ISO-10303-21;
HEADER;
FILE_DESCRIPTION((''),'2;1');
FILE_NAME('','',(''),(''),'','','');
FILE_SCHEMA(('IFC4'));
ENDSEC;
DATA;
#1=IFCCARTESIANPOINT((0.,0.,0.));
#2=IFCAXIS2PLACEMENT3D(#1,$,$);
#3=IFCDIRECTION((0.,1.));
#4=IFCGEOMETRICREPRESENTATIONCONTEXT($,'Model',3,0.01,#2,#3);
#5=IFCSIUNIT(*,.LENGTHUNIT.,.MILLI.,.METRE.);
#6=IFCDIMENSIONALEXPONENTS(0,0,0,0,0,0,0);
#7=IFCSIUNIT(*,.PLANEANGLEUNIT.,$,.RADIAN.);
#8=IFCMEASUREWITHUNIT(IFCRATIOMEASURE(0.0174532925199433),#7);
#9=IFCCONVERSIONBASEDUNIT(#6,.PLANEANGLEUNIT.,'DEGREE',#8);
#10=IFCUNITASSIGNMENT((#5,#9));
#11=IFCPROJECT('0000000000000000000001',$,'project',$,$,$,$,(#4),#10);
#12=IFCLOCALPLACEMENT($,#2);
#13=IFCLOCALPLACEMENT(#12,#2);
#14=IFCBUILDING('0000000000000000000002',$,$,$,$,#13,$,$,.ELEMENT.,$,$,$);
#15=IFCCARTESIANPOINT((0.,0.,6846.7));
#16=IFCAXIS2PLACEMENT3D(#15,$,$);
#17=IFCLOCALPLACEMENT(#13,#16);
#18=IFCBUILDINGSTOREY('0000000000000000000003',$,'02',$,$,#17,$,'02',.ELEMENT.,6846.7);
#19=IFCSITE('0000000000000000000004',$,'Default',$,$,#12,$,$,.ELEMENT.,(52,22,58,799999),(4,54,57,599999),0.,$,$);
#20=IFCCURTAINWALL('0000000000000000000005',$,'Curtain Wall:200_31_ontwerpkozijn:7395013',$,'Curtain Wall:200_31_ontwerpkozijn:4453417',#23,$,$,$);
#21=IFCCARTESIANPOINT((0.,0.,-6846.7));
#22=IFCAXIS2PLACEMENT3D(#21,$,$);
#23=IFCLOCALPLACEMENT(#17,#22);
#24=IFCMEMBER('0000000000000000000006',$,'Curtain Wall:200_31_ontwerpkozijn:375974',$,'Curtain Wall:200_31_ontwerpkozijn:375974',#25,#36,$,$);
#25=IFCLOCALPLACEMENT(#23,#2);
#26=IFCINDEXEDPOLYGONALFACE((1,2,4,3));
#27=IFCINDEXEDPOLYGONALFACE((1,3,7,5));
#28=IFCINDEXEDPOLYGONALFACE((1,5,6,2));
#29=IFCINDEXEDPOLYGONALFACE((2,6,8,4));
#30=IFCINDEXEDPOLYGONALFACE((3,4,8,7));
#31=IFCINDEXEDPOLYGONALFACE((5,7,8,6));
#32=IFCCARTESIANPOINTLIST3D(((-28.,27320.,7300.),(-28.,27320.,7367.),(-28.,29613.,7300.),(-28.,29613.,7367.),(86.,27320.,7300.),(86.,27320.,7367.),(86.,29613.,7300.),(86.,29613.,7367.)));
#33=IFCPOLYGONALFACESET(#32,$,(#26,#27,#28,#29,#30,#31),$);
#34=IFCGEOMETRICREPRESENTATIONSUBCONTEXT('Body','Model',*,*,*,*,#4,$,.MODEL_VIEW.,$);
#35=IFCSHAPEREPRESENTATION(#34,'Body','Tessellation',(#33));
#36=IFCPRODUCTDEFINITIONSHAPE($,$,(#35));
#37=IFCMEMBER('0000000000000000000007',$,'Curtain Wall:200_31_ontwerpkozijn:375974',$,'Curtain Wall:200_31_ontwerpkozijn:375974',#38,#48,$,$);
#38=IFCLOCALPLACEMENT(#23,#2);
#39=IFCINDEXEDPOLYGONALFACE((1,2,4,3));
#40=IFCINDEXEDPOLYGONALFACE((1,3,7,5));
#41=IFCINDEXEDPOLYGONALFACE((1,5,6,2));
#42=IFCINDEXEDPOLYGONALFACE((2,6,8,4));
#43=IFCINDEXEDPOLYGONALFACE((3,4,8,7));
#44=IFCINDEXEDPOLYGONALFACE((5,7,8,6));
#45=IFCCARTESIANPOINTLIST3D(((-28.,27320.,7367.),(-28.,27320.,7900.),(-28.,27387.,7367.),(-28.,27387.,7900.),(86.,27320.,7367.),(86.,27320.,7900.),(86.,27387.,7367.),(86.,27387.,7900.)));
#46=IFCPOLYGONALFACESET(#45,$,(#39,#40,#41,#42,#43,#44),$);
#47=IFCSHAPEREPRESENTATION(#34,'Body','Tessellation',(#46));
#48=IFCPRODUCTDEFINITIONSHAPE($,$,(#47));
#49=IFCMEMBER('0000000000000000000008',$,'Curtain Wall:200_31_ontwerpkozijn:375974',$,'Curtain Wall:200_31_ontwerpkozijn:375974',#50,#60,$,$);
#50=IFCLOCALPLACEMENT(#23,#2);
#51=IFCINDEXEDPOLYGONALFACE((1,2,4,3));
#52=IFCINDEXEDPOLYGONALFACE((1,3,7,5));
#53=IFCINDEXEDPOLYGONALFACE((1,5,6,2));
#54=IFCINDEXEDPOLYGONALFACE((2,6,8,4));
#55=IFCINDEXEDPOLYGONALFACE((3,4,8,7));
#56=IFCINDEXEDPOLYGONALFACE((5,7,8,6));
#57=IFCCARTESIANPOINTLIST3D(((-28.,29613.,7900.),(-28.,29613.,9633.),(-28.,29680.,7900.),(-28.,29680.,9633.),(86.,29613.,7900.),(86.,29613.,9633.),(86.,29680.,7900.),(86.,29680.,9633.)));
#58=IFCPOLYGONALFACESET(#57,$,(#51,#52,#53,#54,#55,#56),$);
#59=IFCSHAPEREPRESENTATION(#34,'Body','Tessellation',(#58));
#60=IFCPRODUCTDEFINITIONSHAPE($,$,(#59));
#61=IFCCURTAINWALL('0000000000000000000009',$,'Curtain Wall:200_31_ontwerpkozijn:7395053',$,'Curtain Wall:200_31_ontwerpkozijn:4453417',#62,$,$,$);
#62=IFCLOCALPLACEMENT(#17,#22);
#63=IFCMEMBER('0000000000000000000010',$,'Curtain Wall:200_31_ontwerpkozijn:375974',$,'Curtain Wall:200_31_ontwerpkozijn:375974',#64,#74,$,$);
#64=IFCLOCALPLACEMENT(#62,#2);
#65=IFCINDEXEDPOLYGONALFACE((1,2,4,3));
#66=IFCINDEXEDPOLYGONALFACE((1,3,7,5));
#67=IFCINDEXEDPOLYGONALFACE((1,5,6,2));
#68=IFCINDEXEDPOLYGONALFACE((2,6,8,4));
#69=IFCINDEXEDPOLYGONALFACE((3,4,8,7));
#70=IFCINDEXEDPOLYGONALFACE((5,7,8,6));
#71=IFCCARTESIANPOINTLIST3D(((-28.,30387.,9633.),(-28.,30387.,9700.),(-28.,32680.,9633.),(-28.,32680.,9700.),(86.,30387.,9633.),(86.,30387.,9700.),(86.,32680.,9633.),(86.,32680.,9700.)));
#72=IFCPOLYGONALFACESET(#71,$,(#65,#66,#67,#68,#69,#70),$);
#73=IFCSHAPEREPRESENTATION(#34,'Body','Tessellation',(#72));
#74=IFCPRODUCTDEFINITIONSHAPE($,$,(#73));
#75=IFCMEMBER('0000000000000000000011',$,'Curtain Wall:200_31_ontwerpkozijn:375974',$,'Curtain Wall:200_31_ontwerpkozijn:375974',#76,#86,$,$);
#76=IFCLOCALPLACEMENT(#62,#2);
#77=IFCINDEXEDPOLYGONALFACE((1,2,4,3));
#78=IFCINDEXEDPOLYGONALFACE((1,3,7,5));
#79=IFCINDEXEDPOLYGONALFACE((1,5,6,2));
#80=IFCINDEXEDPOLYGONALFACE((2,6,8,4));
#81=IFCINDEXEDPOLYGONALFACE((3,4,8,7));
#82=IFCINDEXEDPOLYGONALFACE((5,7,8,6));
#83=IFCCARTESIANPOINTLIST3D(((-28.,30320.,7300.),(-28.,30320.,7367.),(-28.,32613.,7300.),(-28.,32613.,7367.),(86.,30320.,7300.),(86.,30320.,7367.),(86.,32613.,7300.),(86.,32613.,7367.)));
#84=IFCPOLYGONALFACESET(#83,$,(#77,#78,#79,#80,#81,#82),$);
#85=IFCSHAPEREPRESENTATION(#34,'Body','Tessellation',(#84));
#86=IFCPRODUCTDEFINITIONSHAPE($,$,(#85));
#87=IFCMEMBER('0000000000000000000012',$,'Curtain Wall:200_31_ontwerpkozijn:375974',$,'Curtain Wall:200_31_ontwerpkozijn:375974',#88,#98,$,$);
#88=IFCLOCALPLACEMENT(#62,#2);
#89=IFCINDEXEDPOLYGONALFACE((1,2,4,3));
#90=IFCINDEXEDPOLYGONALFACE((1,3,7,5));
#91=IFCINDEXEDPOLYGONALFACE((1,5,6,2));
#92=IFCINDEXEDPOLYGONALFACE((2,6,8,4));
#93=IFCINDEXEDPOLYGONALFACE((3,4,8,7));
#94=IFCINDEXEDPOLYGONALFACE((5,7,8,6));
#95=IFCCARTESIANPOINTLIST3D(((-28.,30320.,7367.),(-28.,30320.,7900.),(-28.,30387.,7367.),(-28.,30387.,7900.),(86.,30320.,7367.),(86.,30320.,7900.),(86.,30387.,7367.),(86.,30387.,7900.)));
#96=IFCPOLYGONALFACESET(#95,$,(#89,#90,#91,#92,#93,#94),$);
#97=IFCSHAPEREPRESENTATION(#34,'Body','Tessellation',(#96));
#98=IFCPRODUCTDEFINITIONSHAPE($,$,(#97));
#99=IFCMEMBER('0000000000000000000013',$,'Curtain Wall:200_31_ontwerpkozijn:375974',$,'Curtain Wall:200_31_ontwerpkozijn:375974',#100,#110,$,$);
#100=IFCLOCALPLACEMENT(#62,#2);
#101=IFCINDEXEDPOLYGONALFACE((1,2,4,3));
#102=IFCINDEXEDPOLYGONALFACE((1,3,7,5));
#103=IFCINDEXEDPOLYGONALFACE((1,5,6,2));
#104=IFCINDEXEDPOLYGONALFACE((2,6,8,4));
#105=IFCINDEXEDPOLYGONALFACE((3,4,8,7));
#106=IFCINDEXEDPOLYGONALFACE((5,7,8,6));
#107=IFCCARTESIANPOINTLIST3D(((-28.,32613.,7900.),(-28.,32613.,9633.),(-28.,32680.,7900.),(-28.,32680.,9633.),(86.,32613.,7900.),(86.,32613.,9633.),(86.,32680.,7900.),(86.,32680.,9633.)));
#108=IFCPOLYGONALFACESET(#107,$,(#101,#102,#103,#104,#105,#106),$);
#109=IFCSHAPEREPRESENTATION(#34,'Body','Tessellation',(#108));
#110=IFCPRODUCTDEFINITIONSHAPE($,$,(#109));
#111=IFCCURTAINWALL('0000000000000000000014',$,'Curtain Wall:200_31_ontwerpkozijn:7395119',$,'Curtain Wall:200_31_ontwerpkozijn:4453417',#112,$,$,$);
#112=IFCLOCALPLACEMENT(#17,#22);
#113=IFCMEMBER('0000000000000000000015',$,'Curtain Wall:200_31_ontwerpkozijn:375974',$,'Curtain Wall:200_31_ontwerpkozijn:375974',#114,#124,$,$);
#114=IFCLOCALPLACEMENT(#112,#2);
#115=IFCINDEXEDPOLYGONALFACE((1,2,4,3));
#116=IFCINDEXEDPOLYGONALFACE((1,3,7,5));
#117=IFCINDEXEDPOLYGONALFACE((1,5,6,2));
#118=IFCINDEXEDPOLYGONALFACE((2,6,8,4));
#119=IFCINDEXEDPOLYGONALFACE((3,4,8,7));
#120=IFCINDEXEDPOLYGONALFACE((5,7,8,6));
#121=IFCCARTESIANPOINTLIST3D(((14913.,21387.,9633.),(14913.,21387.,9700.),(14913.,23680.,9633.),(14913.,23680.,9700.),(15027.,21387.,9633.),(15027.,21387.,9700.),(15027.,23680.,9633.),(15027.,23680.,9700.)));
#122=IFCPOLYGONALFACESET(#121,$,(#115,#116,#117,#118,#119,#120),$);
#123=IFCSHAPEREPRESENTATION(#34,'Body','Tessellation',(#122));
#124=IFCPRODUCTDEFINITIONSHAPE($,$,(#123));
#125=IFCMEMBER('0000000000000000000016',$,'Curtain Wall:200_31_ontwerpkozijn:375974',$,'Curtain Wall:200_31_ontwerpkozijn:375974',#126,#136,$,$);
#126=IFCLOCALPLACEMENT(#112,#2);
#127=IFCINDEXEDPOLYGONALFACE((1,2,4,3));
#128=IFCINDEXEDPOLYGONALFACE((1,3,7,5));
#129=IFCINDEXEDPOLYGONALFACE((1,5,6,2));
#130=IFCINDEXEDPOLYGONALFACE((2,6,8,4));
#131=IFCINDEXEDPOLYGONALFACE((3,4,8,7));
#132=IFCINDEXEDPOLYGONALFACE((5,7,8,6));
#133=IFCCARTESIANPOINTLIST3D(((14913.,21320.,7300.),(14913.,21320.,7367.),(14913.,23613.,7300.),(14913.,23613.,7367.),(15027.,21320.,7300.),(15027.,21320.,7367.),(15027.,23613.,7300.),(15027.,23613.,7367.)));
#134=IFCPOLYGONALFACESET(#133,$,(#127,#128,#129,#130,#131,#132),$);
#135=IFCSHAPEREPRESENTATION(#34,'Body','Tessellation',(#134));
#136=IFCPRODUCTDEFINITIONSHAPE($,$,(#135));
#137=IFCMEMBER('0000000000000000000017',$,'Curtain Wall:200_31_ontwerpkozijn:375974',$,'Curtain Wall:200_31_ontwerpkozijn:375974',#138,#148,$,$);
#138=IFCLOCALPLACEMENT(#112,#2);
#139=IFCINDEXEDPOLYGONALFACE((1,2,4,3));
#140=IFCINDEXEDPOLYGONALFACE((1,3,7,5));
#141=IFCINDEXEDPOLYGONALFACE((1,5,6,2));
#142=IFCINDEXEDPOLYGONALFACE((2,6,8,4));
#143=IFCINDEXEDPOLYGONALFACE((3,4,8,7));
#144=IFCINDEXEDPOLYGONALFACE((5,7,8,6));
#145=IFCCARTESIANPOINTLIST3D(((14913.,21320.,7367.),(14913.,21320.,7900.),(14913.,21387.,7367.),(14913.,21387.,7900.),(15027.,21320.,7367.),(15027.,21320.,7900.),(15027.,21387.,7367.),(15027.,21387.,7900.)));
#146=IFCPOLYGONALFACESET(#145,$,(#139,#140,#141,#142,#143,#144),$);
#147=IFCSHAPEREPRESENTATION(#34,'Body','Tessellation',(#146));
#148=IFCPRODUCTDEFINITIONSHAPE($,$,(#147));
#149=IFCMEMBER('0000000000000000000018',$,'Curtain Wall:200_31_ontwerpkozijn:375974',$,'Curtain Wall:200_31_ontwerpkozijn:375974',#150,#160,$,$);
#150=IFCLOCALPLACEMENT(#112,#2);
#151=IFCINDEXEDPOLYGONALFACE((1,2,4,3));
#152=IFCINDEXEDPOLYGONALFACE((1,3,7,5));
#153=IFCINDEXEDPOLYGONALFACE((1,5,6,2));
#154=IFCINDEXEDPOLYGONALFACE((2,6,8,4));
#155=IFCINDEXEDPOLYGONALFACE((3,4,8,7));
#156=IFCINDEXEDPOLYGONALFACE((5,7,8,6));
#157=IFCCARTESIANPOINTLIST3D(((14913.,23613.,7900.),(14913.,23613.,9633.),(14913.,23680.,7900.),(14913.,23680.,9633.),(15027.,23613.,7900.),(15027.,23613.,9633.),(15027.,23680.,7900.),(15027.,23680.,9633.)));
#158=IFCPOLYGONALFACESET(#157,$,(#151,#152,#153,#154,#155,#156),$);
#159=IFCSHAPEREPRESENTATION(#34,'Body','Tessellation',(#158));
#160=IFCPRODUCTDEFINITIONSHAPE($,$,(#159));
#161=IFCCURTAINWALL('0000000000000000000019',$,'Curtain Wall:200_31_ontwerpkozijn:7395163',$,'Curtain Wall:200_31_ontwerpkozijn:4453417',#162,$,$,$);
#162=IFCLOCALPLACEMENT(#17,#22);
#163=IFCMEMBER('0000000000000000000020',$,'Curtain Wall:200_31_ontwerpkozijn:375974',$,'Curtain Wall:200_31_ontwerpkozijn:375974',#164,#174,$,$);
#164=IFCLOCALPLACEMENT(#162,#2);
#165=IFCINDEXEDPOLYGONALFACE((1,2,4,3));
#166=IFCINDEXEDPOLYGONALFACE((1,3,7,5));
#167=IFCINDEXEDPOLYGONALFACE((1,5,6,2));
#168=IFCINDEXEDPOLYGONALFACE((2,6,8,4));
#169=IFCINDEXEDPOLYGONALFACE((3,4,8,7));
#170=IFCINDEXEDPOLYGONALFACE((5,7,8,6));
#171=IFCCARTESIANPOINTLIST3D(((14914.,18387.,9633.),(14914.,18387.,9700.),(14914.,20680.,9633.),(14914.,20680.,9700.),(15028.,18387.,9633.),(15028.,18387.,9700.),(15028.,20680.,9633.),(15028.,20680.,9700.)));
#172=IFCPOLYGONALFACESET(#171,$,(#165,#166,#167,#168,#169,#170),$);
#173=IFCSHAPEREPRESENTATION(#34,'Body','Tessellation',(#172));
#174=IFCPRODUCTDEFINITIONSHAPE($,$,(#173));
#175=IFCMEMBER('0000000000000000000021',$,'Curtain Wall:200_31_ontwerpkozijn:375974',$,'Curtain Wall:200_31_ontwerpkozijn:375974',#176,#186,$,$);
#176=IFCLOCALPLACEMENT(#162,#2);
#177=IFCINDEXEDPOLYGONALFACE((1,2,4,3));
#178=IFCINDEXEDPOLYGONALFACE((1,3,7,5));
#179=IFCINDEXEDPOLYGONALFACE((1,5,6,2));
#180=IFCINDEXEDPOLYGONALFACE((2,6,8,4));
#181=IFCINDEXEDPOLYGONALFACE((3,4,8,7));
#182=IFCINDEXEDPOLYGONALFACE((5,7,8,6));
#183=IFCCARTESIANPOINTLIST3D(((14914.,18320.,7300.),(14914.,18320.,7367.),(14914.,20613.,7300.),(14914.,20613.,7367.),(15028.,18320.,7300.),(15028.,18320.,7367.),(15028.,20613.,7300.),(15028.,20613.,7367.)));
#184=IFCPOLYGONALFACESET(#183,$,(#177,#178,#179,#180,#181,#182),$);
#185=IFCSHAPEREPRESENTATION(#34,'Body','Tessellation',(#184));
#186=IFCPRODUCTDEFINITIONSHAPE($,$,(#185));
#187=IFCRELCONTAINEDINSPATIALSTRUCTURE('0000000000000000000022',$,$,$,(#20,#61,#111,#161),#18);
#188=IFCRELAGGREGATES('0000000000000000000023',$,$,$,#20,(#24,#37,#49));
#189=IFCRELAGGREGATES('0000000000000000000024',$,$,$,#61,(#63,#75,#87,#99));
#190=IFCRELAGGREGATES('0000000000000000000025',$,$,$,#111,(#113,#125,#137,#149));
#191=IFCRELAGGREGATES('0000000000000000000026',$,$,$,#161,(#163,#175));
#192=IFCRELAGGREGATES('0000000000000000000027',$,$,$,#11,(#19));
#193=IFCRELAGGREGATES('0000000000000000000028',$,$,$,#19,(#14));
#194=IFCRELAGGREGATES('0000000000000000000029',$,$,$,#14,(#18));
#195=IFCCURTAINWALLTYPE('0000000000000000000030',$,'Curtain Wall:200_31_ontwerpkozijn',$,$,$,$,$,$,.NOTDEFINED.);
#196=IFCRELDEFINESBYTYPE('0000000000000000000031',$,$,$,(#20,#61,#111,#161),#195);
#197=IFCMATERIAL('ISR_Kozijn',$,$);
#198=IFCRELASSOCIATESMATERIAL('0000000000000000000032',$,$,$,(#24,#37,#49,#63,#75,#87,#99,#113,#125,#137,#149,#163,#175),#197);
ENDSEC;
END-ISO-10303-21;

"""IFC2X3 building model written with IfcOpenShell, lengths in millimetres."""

from ifc_helpers import new_model, entity, si_unit, converted_unit, direction, frame, frame_2d, origin, origin_2d_with_axis, place, context, subcontext, project, spatial, rectangle, extrude, material, type_object, element, aggregate, save


model = new_model("IFC2X3")

# Units and contexts
model_context = context("Model", 3, precision=0.01, world=origin(), true_north=direction((0.0, 1.0)))
body_context = subcontext(model_context, "Body", "Model", "MODEL_VIEW")
ifc_project = project(units=[si_unit("LENGTHUNIT", "METRE", prefix="MILLI"), converted_unit("PLANEANGLEUNIT", "DEGREE", entity("IfcRatioMeasure", 0.0174532925199433), si_unit("PLANEANGLEUNIT", "RADIAN"), dimensions=[0, 0, 0, 0, 0, 0, 0])], contexts=[model_context])

# Site, building, storey
site_placement = place(None, origin())
site = spatial("IfcSite", under=ifc_project, at=site_placement, Name="Default", CompositionType="ELEMENT", RefLatitude=(52, 22, 58, 799999), RefLongitude=(4, 54, 57, 599999), RefElevation=0.0)
building_placement = place(site_placement, origin())
building = spatial("IfcBuilding", under=site, at=building_placement, CompositionType="ELEMENT")
storey_placement = place(building_placement, frame((0.0, 0.0, 6846.7)))
storey = spatial("IfcBuildingStorey", under=building, at=storey_placement, Name="02", LongName="02", CompositionType="ELEMENT", Elevation=6846.7)

# Shared definitions
curtain_wall_type = type_object("IfcCurtainWallType", Name="Curtain Wall:200_31_ontwerpkozijn", PredefinedType="NOTDEFINED")
ifc_material = material(Name="ISR_Kozijn")

# Curtain walls, members
curtain_wall_1_placement = place(storey_placement, frame((0.0, 0.0, -6846.7)))
curtain_wall_1 = element("IfcCurtainWall", 1, at=curtain_wall_1_placement, inside=storey, type_object=curtain_wall_type, Name="Curtain Wall:200_31_ontwerpkozijn:7395013", ObjectType="Curtain Wall:200_31_ontwerpkozijn:4453417")
member_1_placement = place(curtain_wall_1_placement, origin())
member_1 = element("IfcMember", 2, at=member_1_placement, material=ifc_material, Name="Curtain Wall:200_31_ontwerpkozijn:375974", ObjectType="Curtain Wall:200_31_ontwerpkozijn:375974", context=body_context, shape_type="SweptSolid", body=[
    extrude(rectangle(XDim=67.0, YDim=114.0, at=frame_2d((0.0, 0.0), x_axis=(1.0, 0.0))), frame((29.0, 29613.0, 7333.5), z_axis=(0.0, -1.0, 0.0), x_axis=(0.0, 0.0, -1.0)), (0.0, 0.0, 1.0), 2293.0),
])
member_2_placement = place(curtain_wall_1_placement, origin())
member_2 = element("IfcMember", 3, at=member_2_placement, material=ifc_material, Name="Curtain Wall:200_31_ontwerpkozijn:375974", ObjectType="Curtain Wall:200_31_ontwerpkozijn:375974", context=body_context, shape_type="SweptSolid", body=[
    extrude(rectangle(XDim=114.0, YDim=67.0, at=origin_2d_with_axis()), frame((29.0, 27353.5, 7367.0), z_axis=(0.0, 0.0, 1.0), x_axis=(-1.0, 0.0, 0.0)), (0.0, 0.0, 1.0), 533.0),
])
member_3_placement = place(curtain_wall_1_placement, origin())
member_3 = element("IfcMember", 4, at=member_3_placement, material=ifc_material, Name="Curtain Wall:200_31_ontwerpkozijn:375974", ObjectType="Curtain Wall:200_31_ontwerpkozijn:375974", context=body_context, shape_type="SweptSolid", body=[
    extrude(rectangle(XDim=114.0, YDim=67.0, at=origin_2d_with_axis()), frame((29.0, 29646.5, 9633.0), z_axis=(0.0, 0.0, -1.0), x_axis=(-1.0, 0.0, 0.0)), (0.0, 0.0, 1.0), 1733.0),
])
aggregate(curtain_wall_1, [member_1, member_2, member_3])
curtain_wall_2_placement = place(storey_placement, frame((0.0, 0.0, -6846.7)))
curtain_wall_2 = element("IfcCurtainWall", 5, at=curtain_wall_2_placement, inside=storey, type_object=curtain_wall_type, Name="Curtain Wall:200_31_ontwerpkozijn:7395053", ObjectType="Curtain Wall:200_31_ontwerpkozijn:4453417")
member_4_placement = place(curtain_wall_2_placement, origin())
member_4 = element("IfcMember", 6, at=member_4_placement, material=ifc_material, Name="Curtain Wall:200_31_ontwerpkozijn:375974", ObjectType="Curtain Wall:200_31_ontwerpkozijn:375974", context=body_context, shape_type="SweptSolid", body=[
    extrude(rectangle(XDim=67.0, YDim=114.0, at=origin_2d_with_axis()), frame((29.0, 30387.0, 9666.5), z_axis=(0.0, 1.0, 0.0), x_axis=(0.0, 0.0, -1.0)), (0.0, 0.0, 1.0), 2293.0),
])
member_5_placement = place(curtain_wall_2_placement, origin())
member_5 = element("IfcMember", 7, at=member_5_placement, material=ifc_material, Name="Curtain Wall:200_31_ontwerpkozijn:375974", ObjectType="Curtain Wall:200_31_ontwerpkozijn:375974", context=body_context, shape_type="SweptSolid", body=[
    extrude(rectangle(XDim=67.0, YDim=114.0, at=frame_2d((0.0, 0.0), x_axis=(1.0, 0.0))), frame((29.0, 32613.0, 7333.5), z_axis=(0.0, -1.0, 0.0), x_axis=(0.0, 0.0, -1.0)), (0.0, 0.0, 1.0), 2293.0),
])
member_6_placement = place(curtain_wall_2_placement, origin())
member_6 = element("IfcMember", 8, at=member_6_placement, material=ifc_material, Name="Curtain Wall:200_31_ontwerpkozijn:375974", ObjectType="Curtain Wall:200_31_ontwerpkozijn:375974", context=body_context, shape_type="SweptSolid", body=[
    extrude(rectangle(XDim=114.0, YDim=67.0, at=origin_2d_with_axis()), frame((29.0, 30353.5, 7367.0), z_axis=(0.0, 0.0, 1.0), x_axis=(-1.0, 0.0, 0.0)), (0.0, 0.0, 1.0), 533.0),
])
member_7_placement = place(curtain_wall_2_placement, origin())
member_7 = element("IfcMember", 9, at=member_7_placement, material=ifc_material, Name="Curtain Wall:200_31_ontwerpkozijn:375974", ObjectType="Curtain Wall:200_31_ontwerpkozijn:375974", context=body_context, shape_type="SweptSolid", body=[
    extrude(rectangle(XDim=114.0, YDim=67.0, at=origin_2d_with_axis()), frame((29.0, 32646.5, 9633.0), z_axis=(0.0, 0.0, -1.0), x_axis=(-1.0, 0.0, 0.0)), (0.0, 0.0, 1.0), 1733.0),
])
aggregate(curtain_wall_2, [member_4, member_5, member_6, member_7])
curtain_wall_3_placement = place(storey_placement, frame((0.0, 0.0, -6846.7)))
curtain_wall_3 = element("IfcCurtainWall", 10, at=curtain_wall_3_placement, inside=storey, type_object=curtain_wall_type, Name="Curtain Wall:200_31_ontwerpkozijn:7395119", ObjectType="Curtain Wall:200_31_ontwerpkozijn:4453417")
member_8_placement = place(curtain_wall_3_placement, origin())
member_8 = element("IfcMember", 11, at=member_8_placement, material=ifc_material, Name="Curtain Wall:200_31_ontwerpkozijn:375974", ObjectType="Curtain Wall:200_31_ontwerpkozijn:375974", context=body_context, shape_type="SweptSolid", body=[
    extrude(rectangle(XDim=67.0, YDim=114.0, at=origin_2d_with_axis()), frame((14970.0, 21387.0, 9666.5), z_axis=(0.0, 1.0, 0.0), x_axis=(0.0, 0.0, -1.0)), (0.0, 0.0, 1.0), 2293.0),
])
member_9_placement = place(curtain_wall_3_placement, origin())
member_9 = element("IfcMember", 12, at=member_9_placement, material=ifc_material, Name="Curtain Wall:200_31_ontwerpkozijn:375974", ObjectType="Curtain Wall:200_31_ontwerpkozijn:375974", context=body_context, shape_type="SweptSolid", body=[
    extrude(rectangle(XDim=67.0, YDim=114.0, at=origin_2d_with_axis()), frame((14970.0, 23613.0, 7333.5), z_axis=(0.0, -1.0, 0.0), x_axis=(0.0, 0.0, -1.0)), (0.0, 0.0, 1.0), 2293.0),
])
member_10_placement = place(curtain_wall_3_placement, origin())
member_10 = element("IfcMember", 13, at=member_10_placement, material=ifc_material, Name="Curtain Wall:200_31_ontwerpkozijn:375974", ObjectType="Curtain Wall:200_31_ontwerpkozijn:375974", context=body_context, shape_type="SweptSolid", body=[
    extrude(rectangle(XDim=114.0, YDim=67.0, at=origin_2d_with_axis()), frame((14970.0, 21353.5, 7367.0), z_axis=(0.0, 0.0, 1.0), x_axis=(-1.0, 0.0, 0.0)), (0.0, 0.0, 1.0), 533.0),
])
member_11_placement = place(curtain_wall_3_placement, origin())
member_11 = element("IfcMember", 14, at=member_11_placement, material=ifc_material, Name="Curtain Wall:200_31_ontwerpkozijn:375974", ObjectType="Curtain Wall:200_31_ontwerpkozijn:375974", context=body_context, shape_type="SweptSolid", body=[
    extrude(rectangle(XDim=114.0, YDim=67.0, at=origin_2d_with_axis()), frame((14970.0, 23646.5, 9633.0), z_axis=(0.0, 0.0, -1.0), x_axis=(-1.0, 0.0, 0.0)), (0.0, 0.0, 1.0), 1733.0),
])
aggregate(curtain_wall_3, [member_8, member_9, member_10, member_11])
curtain_wall_4_placement = place(storey_placement, frame((0.0, 0.0, -6846.7)))
curtain_wall_4 = element("IfcCurtainWall", 15, at=curtain_wall_4_placement, inside=storey, type_object=curtain_wall_type, Name="Curtain Wall:200_31_ontwerpkozijn:7395163", ObjectType="Curtain Wall:200_31_ontwerpkozijn:4453417")
member_12_placement = place(curtain_wall_4_placement, origin())
member_12 = element("IfcMember", 16, at=member_12_placement, material=ifc_material, Name="Curtain Wall:200_31_ontwerpkozijn:375974", ObjectType="Curtain Wall:200_31_ontwerpkozijn:375974", context=body_context, shape_type="SweptSolid", body=[
    extrude(rectangle(XDim=67.0, YDim=114.0, at=origin_2d_with_axis()), frame((14971.0, 18387.0, 9666.5), z_axis=(0.0, 1.0, 0.0), x_axis=(0.0, 0.0, -1.0)), (0.0, 0.0, 1.0), 2293.0),
])
member_13_placement = place(curtain_wall_4_placement, origin())
member_13 = element("IfcMember", 17, at=member_13_placement, material=ifc_material, Name="Curtain Wall:200_31_ontwerpkozijn:375974", ObjectType="Curtain Wall:200_31_ontwerpkozijn:375974", context=body_context, shape_type="SweptSolid", body=[
    extrude(rectangle(XDim=67.0, YDim=114.0, at=origin_2d_with_axis()), frame((14971.0, 20613.0, 7333.5), z_axis=(0.0, -1.0, 0.0), x_axis=(0.0, 0.0, -1.0)), (0.0, 0.0, 1.0), 2293.0),
])
aggregate(curtain_wall_4, [member_12, member_13])

save(model, "model.ifc")
